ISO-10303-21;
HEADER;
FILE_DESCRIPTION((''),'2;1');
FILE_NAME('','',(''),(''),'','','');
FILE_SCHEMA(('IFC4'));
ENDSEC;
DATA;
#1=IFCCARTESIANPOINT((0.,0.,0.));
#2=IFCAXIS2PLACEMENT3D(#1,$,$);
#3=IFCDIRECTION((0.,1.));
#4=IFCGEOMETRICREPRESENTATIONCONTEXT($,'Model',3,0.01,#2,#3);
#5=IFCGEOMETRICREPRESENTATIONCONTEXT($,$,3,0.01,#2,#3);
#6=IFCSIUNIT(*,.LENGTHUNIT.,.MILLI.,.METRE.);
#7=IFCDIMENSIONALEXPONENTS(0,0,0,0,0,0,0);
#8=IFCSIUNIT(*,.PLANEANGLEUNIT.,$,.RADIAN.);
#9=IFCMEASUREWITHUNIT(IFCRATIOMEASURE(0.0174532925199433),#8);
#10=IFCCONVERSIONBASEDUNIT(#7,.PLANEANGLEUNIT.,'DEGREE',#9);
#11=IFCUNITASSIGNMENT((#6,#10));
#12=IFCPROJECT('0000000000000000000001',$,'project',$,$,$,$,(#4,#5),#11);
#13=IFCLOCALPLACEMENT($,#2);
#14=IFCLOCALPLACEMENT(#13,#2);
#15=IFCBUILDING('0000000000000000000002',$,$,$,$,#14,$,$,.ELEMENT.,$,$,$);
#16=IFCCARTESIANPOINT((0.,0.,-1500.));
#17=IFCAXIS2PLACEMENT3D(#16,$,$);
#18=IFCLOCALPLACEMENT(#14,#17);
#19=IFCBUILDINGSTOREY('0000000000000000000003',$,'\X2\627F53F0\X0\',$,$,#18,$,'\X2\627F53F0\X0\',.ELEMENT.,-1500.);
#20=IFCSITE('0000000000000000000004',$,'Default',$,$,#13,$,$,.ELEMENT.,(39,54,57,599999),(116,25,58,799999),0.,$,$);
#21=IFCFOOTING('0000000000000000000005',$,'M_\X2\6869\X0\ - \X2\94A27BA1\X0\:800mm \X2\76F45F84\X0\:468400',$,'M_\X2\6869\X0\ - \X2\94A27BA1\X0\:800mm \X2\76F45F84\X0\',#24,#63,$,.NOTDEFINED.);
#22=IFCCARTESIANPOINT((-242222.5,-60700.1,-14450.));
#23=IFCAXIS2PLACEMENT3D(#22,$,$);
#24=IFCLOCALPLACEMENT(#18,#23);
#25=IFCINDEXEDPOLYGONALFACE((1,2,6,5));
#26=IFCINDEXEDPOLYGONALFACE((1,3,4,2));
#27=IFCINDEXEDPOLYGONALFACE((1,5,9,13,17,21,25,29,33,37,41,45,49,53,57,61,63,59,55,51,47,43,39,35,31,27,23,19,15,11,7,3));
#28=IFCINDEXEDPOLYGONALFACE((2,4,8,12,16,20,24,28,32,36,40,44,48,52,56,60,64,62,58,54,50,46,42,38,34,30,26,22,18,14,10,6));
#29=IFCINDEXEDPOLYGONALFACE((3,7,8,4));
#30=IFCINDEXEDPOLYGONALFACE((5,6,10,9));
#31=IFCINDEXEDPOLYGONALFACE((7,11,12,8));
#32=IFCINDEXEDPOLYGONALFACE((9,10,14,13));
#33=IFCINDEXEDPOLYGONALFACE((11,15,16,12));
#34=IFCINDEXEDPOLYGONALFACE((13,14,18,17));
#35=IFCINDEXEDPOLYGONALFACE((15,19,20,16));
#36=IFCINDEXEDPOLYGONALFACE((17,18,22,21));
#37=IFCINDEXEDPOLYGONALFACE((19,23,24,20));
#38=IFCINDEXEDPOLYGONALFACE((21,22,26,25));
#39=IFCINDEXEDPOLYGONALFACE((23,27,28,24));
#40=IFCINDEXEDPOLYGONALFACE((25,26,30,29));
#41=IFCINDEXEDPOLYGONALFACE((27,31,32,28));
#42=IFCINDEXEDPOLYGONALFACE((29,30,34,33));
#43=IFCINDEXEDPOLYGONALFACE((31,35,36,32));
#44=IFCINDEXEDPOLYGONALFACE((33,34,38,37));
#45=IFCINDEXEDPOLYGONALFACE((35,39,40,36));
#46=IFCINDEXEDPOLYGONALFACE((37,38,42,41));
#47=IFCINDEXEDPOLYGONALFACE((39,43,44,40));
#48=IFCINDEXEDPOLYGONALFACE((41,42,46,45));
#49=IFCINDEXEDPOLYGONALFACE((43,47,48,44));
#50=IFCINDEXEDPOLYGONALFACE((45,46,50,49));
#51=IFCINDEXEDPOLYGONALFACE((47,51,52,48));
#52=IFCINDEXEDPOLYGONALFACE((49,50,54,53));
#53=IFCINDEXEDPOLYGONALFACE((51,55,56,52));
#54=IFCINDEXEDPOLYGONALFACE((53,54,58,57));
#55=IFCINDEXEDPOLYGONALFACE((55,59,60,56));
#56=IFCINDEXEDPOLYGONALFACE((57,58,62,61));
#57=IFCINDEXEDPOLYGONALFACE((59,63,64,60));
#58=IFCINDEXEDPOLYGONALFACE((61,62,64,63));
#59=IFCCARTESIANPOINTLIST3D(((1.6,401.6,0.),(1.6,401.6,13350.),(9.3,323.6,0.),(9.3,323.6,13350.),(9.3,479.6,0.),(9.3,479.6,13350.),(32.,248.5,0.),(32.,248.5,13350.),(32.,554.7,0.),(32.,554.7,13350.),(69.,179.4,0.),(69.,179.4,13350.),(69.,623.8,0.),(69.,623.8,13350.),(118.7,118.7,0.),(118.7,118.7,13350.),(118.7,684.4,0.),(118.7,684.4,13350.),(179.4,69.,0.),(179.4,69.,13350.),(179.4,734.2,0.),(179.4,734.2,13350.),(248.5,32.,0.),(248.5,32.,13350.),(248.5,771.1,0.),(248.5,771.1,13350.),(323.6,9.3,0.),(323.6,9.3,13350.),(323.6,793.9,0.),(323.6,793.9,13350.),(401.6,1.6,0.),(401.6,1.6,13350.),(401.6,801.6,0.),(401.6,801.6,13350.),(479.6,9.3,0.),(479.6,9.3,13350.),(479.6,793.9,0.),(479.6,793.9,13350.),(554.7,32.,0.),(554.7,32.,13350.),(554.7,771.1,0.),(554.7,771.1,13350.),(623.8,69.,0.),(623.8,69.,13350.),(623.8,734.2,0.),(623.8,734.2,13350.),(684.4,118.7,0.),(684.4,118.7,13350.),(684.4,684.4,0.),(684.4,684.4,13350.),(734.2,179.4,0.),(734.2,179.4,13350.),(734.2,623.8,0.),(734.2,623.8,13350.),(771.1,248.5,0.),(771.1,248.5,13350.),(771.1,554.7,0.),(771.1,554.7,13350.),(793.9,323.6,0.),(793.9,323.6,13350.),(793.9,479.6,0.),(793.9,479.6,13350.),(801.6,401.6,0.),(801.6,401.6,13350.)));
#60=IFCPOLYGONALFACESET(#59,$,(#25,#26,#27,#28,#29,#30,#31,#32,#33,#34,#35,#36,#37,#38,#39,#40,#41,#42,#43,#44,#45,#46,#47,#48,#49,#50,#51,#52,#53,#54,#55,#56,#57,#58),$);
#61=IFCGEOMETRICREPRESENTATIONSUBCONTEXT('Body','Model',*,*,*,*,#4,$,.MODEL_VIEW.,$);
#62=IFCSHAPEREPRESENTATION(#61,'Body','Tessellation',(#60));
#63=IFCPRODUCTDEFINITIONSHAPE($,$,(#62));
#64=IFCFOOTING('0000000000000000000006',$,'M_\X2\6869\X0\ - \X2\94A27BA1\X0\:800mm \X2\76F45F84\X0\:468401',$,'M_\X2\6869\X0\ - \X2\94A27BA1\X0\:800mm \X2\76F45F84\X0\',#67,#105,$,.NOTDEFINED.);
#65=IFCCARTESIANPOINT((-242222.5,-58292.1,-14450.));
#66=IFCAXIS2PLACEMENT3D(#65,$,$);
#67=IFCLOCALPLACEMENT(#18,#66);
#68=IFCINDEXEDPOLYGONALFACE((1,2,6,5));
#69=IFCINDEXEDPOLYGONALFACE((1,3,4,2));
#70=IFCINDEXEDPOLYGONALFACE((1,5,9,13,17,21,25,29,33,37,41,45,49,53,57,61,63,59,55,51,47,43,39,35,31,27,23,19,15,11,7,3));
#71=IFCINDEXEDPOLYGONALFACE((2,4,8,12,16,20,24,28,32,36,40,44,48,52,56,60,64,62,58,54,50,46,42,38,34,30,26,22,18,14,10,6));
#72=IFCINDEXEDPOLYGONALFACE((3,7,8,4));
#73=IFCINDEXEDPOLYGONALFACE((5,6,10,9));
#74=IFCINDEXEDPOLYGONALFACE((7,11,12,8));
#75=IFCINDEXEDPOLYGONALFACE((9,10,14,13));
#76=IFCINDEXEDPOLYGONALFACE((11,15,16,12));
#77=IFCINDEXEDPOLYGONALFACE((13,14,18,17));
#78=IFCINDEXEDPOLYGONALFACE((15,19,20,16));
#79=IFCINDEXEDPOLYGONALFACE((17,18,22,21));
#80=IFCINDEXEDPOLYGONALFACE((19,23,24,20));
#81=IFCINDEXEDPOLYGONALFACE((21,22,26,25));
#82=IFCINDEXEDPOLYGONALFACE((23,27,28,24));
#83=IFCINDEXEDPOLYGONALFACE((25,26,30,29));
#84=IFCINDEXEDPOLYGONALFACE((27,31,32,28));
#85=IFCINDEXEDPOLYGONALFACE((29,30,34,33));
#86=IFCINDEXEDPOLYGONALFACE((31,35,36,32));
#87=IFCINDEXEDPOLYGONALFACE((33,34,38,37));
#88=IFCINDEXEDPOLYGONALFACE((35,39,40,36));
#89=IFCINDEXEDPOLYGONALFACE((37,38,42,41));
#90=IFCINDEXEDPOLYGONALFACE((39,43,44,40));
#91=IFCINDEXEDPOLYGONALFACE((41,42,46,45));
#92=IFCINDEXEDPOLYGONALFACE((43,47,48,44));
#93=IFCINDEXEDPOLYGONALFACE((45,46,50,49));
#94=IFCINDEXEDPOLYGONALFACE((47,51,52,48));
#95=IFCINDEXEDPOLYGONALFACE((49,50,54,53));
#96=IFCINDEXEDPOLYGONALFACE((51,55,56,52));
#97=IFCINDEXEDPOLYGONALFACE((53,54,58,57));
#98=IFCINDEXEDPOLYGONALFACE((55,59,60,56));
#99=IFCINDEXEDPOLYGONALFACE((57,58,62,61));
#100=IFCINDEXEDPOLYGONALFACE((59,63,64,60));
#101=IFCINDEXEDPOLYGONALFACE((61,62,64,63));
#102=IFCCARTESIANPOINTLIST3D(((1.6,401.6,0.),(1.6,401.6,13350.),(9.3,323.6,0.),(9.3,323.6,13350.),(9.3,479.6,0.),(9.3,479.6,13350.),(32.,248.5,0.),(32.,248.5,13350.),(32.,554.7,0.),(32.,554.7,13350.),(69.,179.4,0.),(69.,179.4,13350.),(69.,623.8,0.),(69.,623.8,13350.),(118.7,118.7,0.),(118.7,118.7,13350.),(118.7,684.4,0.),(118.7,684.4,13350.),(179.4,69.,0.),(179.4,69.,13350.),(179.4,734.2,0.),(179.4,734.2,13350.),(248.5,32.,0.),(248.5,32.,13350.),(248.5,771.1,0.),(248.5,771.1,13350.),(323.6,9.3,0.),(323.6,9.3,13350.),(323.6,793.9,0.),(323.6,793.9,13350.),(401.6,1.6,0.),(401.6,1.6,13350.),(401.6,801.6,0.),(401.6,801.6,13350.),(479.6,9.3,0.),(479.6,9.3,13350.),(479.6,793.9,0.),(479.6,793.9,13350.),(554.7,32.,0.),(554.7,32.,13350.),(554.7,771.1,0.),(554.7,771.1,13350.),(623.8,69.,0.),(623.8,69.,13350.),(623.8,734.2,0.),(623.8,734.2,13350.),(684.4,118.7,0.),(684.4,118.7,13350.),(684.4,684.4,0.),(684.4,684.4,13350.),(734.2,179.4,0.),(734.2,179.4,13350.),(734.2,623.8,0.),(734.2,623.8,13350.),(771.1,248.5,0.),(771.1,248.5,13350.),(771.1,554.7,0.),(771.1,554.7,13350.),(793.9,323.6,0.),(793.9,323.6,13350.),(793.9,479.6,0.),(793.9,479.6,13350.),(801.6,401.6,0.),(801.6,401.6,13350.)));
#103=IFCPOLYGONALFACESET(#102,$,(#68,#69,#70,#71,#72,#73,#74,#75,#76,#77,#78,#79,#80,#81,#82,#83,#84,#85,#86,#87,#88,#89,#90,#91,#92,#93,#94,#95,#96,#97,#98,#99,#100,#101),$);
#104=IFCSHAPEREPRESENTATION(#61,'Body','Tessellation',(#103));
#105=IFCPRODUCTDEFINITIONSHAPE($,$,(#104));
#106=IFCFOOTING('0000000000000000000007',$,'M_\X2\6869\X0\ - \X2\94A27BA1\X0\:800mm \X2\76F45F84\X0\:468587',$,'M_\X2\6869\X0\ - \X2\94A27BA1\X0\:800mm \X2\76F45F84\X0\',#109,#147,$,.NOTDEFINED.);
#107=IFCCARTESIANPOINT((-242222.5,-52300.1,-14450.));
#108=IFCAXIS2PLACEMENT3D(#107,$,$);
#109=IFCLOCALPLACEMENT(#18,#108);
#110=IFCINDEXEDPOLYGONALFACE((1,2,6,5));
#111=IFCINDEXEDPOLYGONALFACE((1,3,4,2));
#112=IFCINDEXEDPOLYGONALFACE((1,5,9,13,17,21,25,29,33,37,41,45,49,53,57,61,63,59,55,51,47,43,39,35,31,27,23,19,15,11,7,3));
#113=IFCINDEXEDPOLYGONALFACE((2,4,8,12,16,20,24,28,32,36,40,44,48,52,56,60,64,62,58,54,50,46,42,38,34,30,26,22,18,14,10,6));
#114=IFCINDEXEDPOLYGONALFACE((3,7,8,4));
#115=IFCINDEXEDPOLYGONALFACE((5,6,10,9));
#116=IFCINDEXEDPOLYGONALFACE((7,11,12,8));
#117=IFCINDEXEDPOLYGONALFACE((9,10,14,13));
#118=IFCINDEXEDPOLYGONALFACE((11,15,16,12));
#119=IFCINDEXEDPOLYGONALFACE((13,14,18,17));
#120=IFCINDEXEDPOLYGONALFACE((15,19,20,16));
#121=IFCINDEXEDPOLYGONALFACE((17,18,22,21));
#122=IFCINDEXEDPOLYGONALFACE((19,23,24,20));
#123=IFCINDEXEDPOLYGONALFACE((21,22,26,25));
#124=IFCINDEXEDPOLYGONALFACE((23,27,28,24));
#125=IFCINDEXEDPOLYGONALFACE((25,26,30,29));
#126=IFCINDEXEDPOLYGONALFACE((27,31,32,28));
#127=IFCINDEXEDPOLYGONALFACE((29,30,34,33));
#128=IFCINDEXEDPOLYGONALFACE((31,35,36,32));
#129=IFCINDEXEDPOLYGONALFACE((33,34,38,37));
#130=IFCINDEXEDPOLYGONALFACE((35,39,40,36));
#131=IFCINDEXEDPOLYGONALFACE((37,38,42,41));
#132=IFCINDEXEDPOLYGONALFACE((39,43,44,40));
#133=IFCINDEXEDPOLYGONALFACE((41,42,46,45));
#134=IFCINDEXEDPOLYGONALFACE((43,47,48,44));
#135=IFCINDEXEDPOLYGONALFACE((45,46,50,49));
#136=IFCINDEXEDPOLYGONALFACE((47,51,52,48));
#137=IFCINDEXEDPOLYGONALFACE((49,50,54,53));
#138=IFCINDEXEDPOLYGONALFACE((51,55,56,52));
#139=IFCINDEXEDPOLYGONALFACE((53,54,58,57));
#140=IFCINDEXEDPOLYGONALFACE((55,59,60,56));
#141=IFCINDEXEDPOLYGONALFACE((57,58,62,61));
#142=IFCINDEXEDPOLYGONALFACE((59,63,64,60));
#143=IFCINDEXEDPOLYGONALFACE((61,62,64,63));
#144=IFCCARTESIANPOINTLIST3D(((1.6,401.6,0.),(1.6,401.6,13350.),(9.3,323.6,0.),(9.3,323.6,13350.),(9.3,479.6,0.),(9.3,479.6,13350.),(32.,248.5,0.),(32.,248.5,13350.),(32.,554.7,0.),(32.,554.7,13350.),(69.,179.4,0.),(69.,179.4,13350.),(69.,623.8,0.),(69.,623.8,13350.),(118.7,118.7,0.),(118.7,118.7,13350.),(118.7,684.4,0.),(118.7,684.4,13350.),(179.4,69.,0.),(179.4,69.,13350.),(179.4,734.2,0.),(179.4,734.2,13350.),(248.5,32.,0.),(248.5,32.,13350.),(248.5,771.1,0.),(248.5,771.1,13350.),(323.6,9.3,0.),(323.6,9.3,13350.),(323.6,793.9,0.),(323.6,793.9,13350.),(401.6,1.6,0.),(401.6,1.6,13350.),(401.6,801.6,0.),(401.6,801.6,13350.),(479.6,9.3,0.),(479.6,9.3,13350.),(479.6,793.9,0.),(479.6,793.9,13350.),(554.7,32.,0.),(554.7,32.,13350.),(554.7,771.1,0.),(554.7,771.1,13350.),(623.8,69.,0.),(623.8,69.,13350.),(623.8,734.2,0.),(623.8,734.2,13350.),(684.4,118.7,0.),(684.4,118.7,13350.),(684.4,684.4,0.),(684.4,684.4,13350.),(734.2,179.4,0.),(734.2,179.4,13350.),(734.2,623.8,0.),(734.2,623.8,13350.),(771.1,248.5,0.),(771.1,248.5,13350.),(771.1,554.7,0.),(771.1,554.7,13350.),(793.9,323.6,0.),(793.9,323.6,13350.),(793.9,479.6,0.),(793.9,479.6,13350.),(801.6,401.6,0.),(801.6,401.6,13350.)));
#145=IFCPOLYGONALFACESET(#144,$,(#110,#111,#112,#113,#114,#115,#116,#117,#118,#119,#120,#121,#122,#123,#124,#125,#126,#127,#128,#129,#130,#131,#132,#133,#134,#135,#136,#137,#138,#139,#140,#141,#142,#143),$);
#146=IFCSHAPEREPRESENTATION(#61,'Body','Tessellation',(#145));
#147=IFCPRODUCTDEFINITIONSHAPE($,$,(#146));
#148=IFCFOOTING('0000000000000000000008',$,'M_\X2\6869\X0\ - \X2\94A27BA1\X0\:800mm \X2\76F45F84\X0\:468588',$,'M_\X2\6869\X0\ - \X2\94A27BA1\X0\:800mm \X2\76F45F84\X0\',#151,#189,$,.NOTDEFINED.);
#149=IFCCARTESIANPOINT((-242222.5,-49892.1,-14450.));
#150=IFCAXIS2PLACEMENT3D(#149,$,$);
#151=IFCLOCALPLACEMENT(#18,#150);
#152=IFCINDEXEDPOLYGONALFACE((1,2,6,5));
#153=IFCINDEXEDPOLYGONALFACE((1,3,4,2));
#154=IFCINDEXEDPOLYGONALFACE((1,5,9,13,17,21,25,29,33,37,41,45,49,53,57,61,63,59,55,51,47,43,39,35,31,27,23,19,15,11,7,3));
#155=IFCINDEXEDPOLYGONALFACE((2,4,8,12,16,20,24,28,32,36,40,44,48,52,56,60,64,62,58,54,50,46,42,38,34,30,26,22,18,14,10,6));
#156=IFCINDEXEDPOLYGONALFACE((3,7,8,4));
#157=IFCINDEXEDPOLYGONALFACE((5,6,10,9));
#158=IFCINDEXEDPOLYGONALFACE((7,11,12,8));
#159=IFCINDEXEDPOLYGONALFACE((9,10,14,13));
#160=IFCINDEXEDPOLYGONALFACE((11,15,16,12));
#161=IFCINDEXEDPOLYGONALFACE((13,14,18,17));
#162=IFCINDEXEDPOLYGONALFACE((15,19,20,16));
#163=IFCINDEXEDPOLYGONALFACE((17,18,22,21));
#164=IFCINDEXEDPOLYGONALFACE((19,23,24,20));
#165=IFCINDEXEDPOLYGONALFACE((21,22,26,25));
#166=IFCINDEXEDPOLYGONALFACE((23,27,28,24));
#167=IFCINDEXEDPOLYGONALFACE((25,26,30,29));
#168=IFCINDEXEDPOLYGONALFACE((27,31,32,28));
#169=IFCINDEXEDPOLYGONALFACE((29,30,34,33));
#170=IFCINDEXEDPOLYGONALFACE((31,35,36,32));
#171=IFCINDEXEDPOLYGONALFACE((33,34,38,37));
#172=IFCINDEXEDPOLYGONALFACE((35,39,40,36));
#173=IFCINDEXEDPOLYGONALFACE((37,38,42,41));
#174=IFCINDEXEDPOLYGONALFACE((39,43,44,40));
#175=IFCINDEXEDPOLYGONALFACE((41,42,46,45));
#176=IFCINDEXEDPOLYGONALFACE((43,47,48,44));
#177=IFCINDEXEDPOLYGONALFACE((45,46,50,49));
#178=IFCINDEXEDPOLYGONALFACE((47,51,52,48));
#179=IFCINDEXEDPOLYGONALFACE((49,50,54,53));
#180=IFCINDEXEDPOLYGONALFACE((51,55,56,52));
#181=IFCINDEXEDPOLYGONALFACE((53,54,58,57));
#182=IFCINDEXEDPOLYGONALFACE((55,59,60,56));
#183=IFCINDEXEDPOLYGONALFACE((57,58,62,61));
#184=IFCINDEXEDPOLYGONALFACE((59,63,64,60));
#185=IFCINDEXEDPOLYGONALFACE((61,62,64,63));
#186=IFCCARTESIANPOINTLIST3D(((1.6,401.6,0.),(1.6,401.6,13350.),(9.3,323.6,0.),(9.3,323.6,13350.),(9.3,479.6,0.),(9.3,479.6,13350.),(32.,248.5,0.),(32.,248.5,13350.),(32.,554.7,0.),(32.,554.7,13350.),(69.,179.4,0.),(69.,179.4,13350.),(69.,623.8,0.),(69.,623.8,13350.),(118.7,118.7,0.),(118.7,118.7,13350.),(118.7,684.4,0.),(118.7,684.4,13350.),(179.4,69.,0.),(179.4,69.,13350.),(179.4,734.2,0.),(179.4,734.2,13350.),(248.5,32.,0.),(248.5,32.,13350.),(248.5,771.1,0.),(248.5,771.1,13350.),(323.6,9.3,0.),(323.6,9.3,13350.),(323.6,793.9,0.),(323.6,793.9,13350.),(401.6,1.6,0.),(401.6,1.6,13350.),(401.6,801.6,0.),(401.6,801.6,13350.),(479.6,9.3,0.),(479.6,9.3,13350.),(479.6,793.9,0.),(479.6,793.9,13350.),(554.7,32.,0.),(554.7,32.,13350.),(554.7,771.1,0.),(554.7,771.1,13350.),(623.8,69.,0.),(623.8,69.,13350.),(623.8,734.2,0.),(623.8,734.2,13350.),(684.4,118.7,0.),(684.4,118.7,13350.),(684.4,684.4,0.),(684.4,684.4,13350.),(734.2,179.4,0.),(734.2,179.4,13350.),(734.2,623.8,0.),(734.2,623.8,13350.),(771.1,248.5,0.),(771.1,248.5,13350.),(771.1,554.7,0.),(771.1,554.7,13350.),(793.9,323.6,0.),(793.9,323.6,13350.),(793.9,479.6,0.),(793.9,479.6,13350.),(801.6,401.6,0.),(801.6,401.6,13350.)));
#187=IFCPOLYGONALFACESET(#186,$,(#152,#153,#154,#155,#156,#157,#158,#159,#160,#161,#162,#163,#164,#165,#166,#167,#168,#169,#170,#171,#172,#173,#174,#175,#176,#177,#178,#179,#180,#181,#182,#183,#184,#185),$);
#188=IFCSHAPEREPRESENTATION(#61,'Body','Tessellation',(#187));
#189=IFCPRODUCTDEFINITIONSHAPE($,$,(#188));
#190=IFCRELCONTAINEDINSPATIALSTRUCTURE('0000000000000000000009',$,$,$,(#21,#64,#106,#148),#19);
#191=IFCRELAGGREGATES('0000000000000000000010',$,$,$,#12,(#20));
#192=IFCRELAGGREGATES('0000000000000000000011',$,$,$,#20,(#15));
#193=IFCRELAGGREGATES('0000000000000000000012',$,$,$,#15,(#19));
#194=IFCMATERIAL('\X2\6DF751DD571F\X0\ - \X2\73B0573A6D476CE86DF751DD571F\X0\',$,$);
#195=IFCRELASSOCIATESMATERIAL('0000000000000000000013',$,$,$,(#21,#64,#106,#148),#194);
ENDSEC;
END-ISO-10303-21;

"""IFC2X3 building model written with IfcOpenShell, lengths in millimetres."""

from ifc_helpers import new_model, entity, si_unit, converted_unit, direction, frame, origin, origin_2d_with_axis, place, context, subcontext, project, spatial, circle, extrude, material, element, save


model = new_model("IFC2X3")

# Units and contexts
model_context = context("Model", 3, precision=0.01, world=origin(), true_north=direction((0.0, 1.0)))
context_of_model = context(None, 3, precision=0.01, world=origin(), true_north=direction((0.0, 1.0)))
body_context = subcontext(model_context, "Body", "Model", "MODEL_VIEW")
ifc_project = project(units=[si_unit("LENGTHUNIT", "METRE", prefix="MILLI"), converted_unit("PLANEANGLEUNIT", "DEGREE", entity("IfcRatioMeasure", 0.0174532925199433), si_unit("PLANEANGLEUNIT", "RADIAN"), dimensions=[0, 0, 0, 0, 0, 0, 0])], contexts=[model_context, context_of_model])

# Site, building, storey
site_placement = place(None, origin())
site = spatial("IfcSite", under=ifc_project, at=site_placement, Name="Default", CompositionType="ELEMENT", RefLatitude=(39, 54, 57, 599999), RefLongitude=(116, 25, 58, 799999), RefElevation=0.0)
building_placement = place(site_placement, origin())
building = spatial("IfcBuilding", under=site, at=building_placement, CompositionType="ELEMENT")
storey_placement = place(building_placement, frame((0.0, 0.0, -1500.0)))
storey = spatial("IfcBuildingStorey", under=building, at=storey_placement, Name="承台", LongName="承台", CompositionType="ELEMENT", Elevation=-1500.0)

# Footings
ifc_material_1 = material(Name="混凝土 - 现场浇注混凝土")
for number, where, name in (
    (1, (-242222.5, -60700.1, -14450.0), "M_桩 - 钢管:800mm 直径:468400"),
    (2, (-242222.5, -58292.1, -14450.0), "M_桩 - 钢管:800mm 直径:468401"),
    (3, (-242222.5, -52300.1, -14450.0), "M_桩 - 钢管:800mm 直径:468587"),
    (4, (-242222.5, -49892.1, -14450.0), "M_桩 - 钢管:800mm 直径:468588"),
):
    element("IfcFooting", number, at=place(storey_placement, frame(where)), inside=storey, material=ifc_material_1, Name=name, ObjectType="M_桩 - 钢管:800mm 直径", PredefinedType="NOTDEFINED", context=body_context, shape_type="SweptSolid", body=[
        extrude(circle(Radius=400.0, at=origin_2d_with_axis()), frame((401.6, 401.6, 0.0), z_axis=(0.0, 0.0, 1.0), x_axis=(0.0, 1.0, 0.0)), (0.0, 0.0, 1.0), 13350.0),
    ])

save(model, "model.ifc")
